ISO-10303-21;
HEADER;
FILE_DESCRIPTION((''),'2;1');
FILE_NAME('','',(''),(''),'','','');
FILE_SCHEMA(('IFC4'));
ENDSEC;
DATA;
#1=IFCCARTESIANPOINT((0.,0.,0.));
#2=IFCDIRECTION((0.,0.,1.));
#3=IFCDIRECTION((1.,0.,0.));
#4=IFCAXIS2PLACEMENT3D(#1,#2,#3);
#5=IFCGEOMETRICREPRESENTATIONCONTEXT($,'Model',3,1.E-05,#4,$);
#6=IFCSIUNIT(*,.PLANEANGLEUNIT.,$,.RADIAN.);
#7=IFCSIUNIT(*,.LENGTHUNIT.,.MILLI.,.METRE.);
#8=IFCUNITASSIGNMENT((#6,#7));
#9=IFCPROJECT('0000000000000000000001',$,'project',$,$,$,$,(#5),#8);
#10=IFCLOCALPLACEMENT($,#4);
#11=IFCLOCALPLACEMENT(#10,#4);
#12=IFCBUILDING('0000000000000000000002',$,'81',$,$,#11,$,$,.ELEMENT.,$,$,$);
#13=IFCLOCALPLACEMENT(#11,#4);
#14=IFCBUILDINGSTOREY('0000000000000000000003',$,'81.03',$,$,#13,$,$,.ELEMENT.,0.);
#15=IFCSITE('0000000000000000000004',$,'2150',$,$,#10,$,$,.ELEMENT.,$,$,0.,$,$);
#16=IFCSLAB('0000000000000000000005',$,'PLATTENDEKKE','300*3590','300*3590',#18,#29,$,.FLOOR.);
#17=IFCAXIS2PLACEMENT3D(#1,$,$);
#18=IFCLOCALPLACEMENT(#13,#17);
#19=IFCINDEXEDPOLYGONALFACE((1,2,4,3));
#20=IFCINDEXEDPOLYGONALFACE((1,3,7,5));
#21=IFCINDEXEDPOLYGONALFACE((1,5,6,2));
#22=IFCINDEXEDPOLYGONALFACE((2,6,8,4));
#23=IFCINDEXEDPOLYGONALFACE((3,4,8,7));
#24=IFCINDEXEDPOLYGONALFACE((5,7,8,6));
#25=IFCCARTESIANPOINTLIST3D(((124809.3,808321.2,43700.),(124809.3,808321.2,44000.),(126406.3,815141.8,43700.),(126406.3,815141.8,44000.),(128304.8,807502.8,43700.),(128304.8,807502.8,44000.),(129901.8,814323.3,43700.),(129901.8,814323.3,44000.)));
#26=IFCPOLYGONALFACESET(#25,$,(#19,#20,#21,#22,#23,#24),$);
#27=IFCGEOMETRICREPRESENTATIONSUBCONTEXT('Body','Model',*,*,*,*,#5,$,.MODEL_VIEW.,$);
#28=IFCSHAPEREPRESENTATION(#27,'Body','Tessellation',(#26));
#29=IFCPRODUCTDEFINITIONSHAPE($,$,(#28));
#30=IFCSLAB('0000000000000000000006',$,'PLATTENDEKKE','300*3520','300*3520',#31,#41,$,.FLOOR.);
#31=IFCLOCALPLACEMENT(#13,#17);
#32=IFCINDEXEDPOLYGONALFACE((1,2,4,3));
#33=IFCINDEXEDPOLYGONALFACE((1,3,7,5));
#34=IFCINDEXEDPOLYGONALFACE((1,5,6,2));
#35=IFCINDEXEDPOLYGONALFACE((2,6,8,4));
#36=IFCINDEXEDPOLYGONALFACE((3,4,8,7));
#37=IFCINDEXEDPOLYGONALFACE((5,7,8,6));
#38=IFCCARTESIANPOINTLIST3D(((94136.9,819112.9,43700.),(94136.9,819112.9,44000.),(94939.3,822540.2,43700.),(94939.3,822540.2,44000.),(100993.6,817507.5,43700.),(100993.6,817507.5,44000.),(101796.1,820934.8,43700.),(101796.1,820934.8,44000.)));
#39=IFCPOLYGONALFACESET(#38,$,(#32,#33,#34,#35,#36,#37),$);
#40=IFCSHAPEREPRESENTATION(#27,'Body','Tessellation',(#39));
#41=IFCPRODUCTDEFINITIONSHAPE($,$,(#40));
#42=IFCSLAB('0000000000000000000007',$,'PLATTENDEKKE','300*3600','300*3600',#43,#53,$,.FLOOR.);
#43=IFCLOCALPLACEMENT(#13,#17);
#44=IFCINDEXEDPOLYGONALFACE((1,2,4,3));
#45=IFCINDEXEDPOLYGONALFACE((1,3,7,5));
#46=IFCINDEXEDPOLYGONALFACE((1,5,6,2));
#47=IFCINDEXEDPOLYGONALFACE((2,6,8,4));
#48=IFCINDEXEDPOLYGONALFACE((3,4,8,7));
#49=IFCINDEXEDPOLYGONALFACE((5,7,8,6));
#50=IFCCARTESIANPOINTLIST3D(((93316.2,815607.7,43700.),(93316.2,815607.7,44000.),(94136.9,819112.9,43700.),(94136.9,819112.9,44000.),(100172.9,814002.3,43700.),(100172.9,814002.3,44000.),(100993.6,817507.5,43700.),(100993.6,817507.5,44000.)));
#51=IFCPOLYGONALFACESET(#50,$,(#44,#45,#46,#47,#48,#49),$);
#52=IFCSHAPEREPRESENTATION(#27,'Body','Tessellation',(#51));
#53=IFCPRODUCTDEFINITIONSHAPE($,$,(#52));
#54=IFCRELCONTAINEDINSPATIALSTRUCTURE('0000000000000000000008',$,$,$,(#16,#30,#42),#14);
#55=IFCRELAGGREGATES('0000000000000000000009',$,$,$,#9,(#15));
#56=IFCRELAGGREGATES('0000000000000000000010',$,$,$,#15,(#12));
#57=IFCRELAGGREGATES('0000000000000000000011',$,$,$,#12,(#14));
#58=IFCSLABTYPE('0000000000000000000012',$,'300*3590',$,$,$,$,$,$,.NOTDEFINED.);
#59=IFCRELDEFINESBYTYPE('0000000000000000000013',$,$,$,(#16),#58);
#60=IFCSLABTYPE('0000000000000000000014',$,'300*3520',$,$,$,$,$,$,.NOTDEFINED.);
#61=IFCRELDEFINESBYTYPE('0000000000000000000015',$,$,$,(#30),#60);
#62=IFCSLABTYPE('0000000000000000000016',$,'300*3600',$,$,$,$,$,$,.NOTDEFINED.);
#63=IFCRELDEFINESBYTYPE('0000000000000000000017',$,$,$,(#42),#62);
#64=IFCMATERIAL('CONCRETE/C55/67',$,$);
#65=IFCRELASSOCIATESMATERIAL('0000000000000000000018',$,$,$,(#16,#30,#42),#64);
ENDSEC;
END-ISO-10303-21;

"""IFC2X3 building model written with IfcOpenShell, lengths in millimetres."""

from ifc_helpers import new_model, si_unit, frame, origin, origin_with_axes, origin_2d_with_axis, place, context, subcontext, project, spatial, rectangle, extrude, source, transform, mapped, material, type_object, element, save


model = new_model("IFC2X3")

# Units and contexts
model_context = context("Model", 3, precision=1e-05, world=origin_with_axes())
body_context = subcontext(model_context, "Body", "Model", "MODEL_VIEW")
ifc_project = project(units=[si_unit("PLANEANGLEUNIT", "RADIAN"), si_unit("LENGTHUNIT", "METRE", prefix="MILLI")], contexts=[model_context])

# Site, building, storey
site_placement = place(None, origin_with_axes())
site = spatial("IfcSite", under=ifc_project, at=site_placement, Name="2150", CompositionType="ELEMENT", RefElevation=0.0)
building_placement = place(site_placement, origin_with_axes())
building = spatial("IfcBuilding", under=site, at=building_placement, Name="81", CompositionType="ELEMENT")
storey_placement = place(building_placement, origin_with_axes())
storey = spatial("IfcBuildingStorey", under=building, at=storey_placement, Name="81.03", CompositionType="ELEMENT", Elevation=0.0)

# Slabs
ifc_material = material(Name="CONCRETE/C55/67")
slab_type_1 = type_object("IfcSlabType", Name="300*3590", PredefinedType="NOTDEFINED")
slab_type_2 = type_object("IfcSlabType", Name="300*3600", PredefinedType="NOTDEFINED")
shared_shape_1 = source(origin(), body_context, "Body", "SweptSolid", [
    extrude(rectangle(XDim=3590.0, YDim=300.0, at=origin_2d_with_axis()), frame((7005.0, 0.0, 0.0), z_axis=(-1.0, 0.0, 0.0), x_axis=(0.0, -1.0, 0.0)), (0.0, 0.0, 1.0), 7005.0),
])
slab_1_placement = place(storey_placement, frame((128154.0, 814732.5, 43850.0), z_axis=(0.0, 0.0, 1.0), x_axis=(-0.227973, -0.973667, 0.0)))
element("IfcSlab", 1, at=slab_1_placement, inside=storey, type_object=slab_type_1, material=ifc_material, Name="PLATTENDEKKE", Description="300*3590", ObjectType="300*3590", PredefinedType="FLOOR", context=body_context, shape_type="MappedRepresentation", body=[
    mapped(shared_shape_1, transform((0.0, 0.0, 0.0))),
])
slab_type_3 = type_object("IfcSlabType", Name="300*3520", PredefinedType="NOTDEFINED")
shared_shape_2 = source(origin(), body_context, "Body", "SweptSolid", [
    extrude(rectangle(XDim=3520.0, YDim=300.0, at=origin_2d_with_axis()), frame((7042.2, 0.0, 0.0), z_axis=(-1.0, 0.0, 0.0), x_axis=(0.0, -1.0, 0.0)), (0.0, 0.0, 1.0), 7042.2),
])
slab_2_placement = place(storey_placement, frame((94538.1, 820826.5, 43850.0), z_axis=(0.0, 0.0, 1.0), x_axis=(0.973667, -0.227974, 0.0)))
element("IfcSlab", 2, at=slab_2_placement, inside=storey, type_object=slab_type_3, material=ifc_material, Name="PLATTENDEKKE", Description="300*3520", ObjectType="300*3520", PredefinedType="FLOOR", context=body_context, shape_type="MappedRepresentation", body=[
    mapped(shared_shape_2, transform((0.0, 0.0, 0.0))),
])
shared_shape_3 = source(origin(), body_context, "Body", "SweptSolid", [
    extrude(rectangle(XDim=3600.0, YDim=300.0, at=origin_2d_with_axis()), frame((7042.2, 0.0, 0.0), z_axis=(-1.0, 0.0, 0.0), x_axis=(0.0, -1.0, 0.0)), (0.0, 0.0, 1.0), 7042.2),
])
slab_3_placement = place(storey_placement, frame((93726.5, 817360.3, 43850.0), z_axis=(0.0, 0.0, 1.0), x_axis=(0.973667, -0.227974, 0.0)))
element("IfcSlab", 3, at=slab_3_placement, inside=storey, type_object=slab_type_2, material=ifc_material, Name="PLATTENDEKKE", Description="300*3600", ObjectType="300*3600", PredefinedType="FLOOR", context=body_context, shape_type="MappedRepresentation", body=[
    mapped(shared_shape_3, transform((0.0, 0.0, 0.0))),
])

save(model, "model.ifc")
